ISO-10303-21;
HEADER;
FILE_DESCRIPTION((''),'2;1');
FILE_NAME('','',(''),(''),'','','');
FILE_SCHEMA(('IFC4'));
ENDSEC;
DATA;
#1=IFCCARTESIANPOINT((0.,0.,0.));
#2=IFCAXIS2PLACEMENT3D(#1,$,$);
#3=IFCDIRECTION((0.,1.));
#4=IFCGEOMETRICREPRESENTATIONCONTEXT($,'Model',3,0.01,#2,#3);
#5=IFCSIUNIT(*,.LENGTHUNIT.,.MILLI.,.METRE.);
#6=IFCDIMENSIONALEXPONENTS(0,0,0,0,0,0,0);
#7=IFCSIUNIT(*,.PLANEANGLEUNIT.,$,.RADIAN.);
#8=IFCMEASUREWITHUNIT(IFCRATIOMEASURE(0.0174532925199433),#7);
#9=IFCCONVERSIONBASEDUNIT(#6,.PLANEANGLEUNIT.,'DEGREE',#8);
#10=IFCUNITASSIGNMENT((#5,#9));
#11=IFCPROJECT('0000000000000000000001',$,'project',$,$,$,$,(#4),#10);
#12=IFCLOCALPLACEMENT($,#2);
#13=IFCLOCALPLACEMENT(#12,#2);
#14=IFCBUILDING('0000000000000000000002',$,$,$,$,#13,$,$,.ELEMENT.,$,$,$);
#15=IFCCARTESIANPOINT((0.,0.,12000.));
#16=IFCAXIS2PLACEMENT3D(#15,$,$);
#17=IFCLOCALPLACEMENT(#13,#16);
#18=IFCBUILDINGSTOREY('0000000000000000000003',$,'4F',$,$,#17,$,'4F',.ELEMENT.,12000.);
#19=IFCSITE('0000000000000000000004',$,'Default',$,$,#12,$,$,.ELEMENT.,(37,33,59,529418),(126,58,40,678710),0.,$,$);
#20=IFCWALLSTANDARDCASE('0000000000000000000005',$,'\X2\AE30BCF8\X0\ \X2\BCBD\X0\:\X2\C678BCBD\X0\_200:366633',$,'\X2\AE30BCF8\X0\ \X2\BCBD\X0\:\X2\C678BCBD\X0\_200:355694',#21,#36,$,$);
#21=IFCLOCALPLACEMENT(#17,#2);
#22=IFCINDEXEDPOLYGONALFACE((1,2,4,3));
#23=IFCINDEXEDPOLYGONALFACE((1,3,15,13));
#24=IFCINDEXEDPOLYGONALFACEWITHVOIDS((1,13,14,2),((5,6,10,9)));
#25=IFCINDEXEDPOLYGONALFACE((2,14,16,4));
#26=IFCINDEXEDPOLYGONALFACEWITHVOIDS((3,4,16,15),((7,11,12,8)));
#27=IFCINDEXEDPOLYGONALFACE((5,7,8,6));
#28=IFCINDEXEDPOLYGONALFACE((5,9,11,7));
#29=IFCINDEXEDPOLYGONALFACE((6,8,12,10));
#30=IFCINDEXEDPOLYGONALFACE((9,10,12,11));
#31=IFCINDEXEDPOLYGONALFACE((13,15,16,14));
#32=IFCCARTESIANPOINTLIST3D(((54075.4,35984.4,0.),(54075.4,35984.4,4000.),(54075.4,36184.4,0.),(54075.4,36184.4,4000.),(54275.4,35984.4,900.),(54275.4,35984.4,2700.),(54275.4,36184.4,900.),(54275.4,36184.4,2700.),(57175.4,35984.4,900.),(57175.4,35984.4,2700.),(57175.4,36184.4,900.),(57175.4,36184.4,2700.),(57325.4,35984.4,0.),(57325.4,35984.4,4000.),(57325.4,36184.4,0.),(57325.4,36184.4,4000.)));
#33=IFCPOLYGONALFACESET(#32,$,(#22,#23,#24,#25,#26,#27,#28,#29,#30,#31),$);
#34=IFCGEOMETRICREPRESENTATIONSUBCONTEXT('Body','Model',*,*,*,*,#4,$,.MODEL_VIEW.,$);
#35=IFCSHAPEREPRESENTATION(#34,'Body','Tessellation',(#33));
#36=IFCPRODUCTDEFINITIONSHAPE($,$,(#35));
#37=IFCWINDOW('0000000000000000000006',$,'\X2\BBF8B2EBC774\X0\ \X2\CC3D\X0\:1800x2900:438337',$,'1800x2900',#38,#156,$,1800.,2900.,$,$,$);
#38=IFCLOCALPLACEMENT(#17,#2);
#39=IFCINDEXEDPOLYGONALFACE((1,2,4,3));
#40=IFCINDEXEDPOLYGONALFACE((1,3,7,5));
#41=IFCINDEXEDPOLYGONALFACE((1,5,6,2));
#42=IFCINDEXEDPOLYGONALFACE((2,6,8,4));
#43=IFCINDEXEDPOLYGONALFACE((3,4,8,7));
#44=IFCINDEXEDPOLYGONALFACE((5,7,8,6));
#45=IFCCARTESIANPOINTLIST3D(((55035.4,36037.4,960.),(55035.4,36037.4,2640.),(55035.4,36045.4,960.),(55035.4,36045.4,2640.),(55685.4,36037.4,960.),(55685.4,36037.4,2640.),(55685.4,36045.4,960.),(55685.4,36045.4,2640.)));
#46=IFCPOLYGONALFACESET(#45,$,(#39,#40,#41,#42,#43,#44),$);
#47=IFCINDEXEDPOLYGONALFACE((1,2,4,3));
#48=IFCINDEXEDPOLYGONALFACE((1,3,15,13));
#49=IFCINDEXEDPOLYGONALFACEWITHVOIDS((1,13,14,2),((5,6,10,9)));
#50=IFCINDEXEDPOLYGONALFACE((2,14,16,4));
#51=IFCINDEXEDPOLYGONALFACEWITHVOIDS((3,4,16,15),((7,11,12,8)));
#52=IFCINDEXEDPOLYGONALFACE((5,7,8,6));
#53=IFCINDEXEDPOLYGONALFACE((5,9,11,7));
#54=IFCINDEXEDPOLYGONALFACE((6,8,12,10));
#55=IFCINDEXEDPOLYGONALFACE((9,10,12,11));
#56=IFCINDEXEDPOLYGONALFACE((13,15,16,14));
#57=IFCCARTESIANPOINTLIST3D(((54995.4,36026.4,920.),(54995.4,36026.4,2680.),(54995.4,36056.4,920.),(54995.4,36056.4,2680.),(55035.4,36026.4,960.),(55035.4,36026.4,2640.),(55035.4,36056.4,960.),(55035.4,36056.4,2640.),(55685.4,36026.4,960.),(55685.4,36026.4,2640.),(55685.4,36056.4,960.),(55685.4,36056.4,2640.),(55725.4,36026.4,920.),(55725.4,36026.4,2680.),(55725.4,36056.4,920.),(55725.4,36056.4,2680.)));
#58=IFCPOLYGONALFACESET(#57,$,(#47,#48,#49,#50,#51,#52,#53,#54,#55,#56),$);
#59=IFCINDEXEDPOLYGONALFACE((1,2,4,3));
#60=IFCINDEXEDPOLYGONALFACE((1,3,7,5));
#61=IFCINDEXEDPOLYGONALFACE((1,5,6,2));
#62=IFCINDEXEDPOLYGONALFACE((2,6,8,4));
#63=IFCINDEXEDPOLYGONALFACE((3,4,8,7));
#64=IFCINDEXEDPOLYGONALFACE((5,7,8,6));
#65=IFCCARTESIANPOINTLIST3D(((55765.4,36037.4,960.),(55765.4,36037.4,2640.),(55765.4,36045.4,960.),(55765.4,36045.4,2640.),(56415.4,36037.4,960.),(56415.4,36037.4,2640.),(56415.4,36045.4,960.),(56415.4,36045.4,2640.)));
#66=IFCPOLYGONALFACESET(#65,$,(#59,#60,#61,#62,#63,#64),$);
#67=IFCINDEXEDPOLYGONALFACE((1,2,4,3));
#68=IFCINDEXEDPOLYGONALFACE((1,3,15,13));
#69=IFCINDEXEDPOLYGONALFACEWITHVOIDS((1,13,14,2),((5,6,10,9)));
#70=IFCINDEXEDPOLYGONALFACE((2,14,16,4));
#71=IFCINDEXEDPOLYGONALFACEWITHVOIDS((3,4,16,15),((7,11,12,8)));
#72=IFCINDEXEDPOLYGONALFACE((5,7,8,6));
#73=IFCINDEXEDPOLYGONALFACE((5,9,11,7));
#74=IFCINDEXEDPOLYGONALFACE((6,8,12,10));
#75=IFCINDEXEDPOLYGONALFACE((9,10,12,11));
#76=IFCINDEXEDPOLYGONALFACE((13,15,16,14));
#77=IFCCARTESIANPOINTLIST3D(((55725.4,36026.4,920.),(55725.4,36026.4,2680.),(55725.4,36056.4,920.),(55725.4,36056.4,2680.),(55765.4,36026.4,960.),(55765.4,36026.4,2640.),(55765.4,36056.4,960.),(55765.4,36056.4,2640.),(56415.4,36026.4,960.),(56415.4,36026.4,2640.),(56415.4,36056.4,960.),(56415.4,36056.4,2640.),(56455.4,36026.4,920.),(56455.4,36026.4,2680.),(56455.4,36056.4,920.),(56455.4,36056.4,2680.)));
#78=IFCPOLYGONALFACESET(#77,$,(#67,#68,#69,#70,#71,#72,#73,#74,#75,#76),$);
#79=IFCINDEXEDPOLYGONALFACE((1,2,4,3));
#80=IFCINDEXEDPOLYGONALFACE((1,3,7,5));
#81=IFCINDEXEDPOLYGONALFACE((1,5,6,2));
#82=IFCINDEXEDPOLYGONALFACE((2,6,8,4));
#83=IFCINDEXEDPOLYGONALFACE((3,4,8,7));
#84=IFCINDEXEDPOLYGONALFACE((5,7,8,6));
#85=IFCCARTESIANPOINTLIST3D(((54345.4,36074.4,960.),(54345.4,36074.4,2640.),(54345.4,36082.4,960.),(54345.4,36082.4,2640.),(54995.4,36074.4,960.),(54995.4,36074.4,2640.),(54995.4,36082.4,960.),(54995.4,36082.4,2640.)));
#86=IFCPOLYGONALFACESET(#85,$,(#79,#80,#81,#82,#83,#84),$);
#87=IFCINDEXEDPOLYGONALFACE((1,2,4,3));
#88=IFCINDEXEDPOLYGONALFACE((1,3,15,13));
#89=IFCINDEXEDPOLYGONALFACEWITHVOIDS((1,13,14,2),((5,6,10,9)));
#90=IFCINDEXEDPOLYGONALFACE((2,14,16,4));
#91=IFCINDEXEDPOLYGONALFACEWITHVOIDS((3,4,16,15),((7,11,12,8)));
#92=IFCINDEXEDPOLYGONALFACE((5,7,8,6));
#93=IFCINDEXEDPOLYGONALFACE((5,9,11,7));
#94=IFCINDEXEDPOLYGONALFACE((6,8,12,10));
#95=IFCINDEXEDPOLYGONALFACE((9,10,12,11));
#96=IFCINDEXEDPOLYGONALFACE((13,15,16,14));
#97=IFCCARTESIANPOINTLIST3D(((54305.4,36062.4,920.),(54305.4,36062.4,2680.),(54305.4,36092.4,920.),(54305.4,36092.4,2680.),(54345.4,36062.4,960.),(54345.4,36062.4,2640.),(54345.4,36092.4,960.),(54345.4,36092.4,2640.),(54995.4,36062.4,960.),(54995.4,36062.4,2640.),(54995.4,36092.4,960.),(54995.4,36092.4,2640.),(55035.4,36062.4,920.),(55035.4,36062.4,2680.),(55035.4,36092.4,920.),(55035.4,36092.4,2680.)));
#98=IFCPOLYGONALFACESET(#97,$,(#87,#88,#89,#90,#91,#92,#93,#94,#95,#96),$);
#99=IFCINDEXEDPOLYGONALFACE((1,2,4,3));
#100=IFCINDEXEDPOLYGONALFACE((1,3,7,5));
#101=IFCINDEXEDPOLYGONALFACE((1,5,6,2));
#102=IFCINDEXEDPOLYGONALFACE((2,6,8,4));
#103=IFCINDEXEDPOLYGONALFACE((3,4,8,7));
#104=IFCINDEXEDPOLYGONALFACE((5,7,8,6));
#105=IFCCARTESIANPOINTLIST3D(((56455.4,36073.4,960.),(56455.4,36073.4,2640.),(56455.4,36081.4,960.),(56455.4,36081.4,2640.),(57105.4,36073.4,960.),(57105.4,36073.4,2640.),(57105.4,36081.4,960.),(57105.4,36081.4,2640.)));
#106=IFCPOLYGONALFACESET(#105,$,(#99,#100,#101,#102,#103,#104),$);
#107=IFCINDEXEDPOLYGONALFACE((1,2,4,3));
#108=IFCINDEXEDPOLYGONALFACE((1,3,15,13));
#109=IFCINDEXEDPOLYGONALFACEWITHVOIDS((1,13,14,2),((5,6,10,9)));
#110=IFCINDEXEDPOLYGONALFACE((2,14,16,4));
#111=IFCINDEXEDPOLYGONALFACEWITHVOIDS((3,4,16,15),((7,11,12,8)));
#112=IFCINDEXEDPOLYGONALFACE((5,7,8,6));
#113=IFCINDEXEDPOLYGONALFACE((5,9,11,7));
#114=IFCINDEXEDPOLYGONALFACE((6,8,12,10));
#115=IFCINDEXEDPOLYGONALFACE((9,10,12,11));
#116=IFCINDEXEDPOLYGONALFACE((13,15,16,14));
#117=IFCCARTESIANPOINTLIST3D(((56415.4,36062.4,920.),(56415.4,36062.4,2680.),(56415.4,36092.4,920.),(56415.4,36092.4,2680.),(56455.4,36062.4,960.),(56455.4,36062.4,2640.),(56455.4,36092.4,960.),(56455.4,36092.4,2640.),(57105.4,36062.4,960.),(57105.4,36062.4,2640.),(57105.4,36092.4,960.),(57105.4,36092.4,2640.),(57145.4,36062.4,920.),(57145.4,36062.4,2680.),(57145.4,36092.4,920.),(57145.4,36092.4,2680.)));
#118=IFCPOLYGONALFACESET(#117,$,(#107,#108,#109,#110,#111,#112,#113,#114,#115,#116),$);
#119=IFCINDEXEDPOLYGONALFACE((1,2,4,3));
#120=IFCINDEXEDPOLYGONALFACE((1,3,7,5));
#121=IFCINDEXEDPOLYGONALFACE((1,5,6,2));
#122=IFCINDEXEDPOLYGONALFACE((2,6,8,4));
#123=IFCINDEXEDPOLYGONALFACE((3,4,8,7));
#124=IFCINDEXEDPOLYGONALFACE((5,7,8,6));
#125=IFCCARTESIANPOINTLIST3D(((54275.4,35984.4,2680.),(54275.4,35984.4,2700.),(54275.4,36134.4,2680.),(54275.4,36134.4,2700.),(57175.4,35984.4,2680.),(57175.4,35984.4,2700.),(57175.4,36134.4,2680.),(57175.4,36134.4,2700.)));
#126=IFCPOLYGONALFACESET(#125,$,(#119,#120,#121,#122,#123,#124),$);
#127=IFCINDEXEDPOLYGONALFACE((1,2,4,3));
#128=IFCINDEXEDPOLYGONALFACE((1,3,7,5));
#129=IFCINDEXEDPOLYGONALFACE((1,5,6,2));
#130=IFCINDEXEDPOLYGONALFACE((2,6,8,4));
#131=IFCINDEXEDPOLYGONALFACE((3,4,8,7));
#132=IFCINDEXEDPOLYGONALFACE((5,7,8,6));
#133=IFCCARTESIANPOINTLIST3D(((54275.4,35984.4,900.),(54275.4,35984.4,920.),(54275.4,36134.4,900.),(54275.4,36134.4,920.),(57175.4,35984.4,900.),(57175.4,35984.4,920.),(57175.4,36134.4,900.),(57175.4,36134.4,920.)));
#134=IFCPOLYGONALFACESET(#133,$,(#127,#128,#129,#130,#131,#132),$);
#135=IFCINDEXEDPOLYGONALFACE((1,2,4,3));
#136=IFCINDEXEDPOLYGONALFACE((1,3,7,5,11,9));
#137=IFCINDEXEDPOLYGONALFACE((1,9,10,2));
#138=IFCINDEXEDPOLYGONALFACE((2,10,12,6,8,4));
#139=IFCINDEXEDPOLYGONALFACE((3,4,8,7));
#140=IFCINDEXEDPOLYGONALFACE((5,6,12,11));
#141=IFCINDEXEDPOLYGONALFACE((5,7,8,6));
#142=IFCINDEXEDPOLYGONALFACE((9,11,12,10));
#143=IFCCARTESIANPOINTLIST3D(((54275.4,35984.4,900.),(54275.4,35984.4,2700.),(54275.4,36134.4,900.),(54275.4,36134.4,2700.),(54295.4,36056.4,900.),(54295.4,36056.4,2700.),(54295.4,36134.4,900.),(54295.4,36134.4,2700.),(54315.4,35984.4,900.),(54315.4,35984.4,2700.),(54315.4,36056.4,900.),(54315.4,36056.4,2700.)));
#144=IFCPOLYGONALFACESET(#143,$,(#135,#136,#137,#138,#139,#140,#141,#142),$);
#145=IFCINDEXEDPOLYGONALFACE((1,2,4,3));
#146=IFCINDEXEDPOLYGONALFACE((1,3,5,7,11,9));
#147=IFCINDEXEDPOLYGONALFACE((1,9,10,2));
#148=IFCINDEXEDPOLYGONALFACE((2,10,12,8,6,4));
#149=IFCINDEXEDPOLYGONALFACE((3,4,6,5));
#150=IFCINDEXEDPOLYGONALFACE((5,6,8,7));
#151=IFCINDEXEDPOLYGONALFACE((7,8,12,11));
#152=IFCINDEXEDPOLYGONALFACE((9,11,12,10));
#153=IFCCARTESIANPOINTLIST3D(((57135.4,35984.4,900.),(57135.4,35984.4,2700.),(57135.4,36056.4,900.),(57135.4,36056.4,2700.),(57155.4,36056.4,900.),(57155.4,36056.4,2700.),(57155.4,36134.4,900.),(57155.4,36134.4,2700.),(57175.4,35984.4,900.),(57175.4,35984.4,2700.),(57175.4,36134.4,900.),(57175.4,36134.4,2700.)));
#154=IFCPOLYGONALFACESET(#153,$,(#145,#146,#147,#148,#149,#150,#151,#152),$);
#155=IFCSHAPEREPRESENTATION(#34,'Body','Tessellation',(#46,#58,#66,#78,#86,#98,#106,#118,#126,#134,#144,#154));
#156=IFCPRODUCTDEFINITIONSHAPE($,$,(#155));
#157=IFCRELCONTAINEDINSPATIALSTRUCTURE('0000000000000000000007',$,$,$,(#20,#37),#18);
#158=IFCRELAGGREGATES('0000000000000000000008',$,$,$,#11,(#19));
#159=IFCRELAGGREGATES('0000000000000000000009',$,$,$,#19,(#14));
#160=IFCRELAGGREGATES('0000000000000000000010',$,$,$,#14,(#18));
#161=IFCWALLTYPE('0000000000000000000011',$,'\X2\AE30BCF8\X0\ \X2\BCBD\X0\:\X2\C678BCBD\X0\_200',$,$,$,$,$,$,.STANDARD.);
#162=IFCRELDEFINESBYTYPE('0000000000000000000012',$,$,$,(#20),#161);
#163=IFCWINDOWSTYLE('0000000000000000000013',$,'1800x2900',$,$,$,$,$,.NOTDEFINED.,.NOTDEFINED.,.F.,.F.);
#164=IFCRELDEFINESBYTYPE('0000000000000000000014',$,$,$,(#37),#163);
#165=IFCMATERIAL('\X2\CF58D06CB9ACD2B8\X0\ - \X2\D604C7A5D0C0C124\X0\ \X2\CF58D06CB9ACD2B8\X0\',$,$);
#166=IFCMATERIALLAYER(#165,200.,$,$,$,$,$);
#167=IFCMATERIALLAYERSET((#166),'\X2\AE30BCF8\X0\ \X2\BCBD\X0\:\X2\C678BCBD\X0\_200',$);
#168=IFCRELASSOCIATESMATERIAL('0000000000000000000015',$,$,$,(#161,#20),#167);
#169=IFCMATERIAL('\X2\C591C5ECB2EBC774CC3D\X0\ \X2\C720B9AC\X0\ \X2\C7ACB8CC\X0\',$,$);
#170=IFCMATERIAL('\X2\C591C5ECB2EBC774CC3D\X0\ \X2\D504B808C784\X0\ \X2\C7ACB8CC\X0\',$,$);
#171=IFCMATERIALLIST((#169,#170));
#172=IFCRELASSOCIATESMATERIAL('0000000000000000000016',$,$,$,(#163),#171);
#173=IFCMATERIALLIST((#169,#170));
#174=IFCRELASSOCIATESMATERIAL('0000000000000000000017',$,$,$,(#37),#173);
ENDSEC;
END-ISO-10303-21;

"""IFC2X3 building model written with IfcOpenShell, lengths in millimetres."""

from ifc_helpers import new_model, entity, si_unit, converted_unit, direction, frame, frame_2d, origin, origin_2d_with_axis, place, context, subcontext, project, spatial, polyline, rectangle, outline, extrude, source, transform, mapped, material, material_list, layer, layer_set, layer_usage, type_object, type_shapes, element, fill, save


model = new_model("IFC2X3")

# Units and contexts
model_context = context("Model", 3, precision=0.01, world=origin(), true_north=direction((0.0, 1.0)))
body_context = subcontext(model_context, "Body", "Model", "MODEL_VIEW")
ifc_project = project(units=[si_unit("LENGTHUNIT", "METRE", prefix="MILLI"), converted_unit("PLANEANGLEUNIT", "DEGREE", entity("IfcRatioMeasure", 0.0174532925199433), si_unit("PLANEANGLEUNIT", "RADIAN"), dimensions=[0, 0, 0, 0, 0, 0, 0])], contexts=[model_context])

# Site, building, storey
site_placement = place(None, origin())
site = spatial("IfcSite", under=ifc_project, at=site_placement, Name="Default", CompositionType="ELEMENT", RefLatitude=(37, 33, 59, 529418), RefLongitude=(126, 58, 40, 678710), RefElevation=0.0)
building_placement = place(site_placement, origin())
building = spatial("IfcBuilding", under=site, at=building_placement, CompositionType="ELEMENT")
storey_placement = place(building_placement, frame((0.0, 0.0, 12000.0)))
storey = spatial("IfcBuildingStorey", under=building, at=storey_placement, Name="4F", LongName="4F", CompositionType="ELEMENT", Elevation=12000.0)

# Wall, opening, window
ifc_material_1 = material(Name="콘크리트 - 현장타설 콘크리트")
ifc_layer_1 = layer(ifc_material_1, 200.0)
ifc_layer_set_1 = layer_set([ifc_layer_1], Name="기본 벽:외벽_200")
ifc_layer_usage_1 = layer_usage(ifc_layer_set_1, "AXIS2", "NEGATIVE", 100.0)
wall_type_1 = type_object("IfcWallType", Name="기본 벽:외벽_200", PredefinedType="STANDARD", material=ifc_layer_set_1)
wall_1_placement = place(storey_placement, frame((57325.4, 36084.4, 0.0), z_axis=(0.0, 0.0, 1.0), x_axis=(-1.0, 0.0, 0.0)))
wall_1 = element("IfcWallStandardCase", 1, at=wall_1_placement, inside=storey, type_object=wall_type_1, material=ifc_layer_usage_1, Name="기본 벽:외벽_200:366633", ObjectType="기본 벽:외벽_200:355694", context=body_context, shape_type="SweptSolid", body=[
    extrude(rectangle(XDim=3250.0, YDim=200.0, at=frame_2d((1625.0, 0.0), x_axis=(-1.0, 0.0))), origin(), (0.0, 0.0, 1.0), 4000.0),
])
opening_1_placement = place(wall_1_placement, frame((150.0, -100.0, 900.0)))
opening_1 = element("IfcOpeningElement", 2, at=opening_1_placement, cuts=wall_1, ObjectType="Opening", context=body_context, shape_type="SweptSolid", body=[
    extrude(rectangle(XDim=1800.0, YDim=2900.0, at=frame_2d((900.0, 1450.0), x_axis=(1.0, 0.0))), frame((0.0, 0.0, 0.0), z_axis=(0.0, 1.0, 0.0), x_axis=(0.0, 0.0, 1.0)), (0.0, 0.0, 1.0), 200.0),
])
ifc_material_2 = material(Name="양여닫이창 유리 재료")
ifc_material_3 = material(Name="양여닫이창 프레임 재료")
ifc_material_list_1 = material_list([ifc_material_2, ifc_material_3])
ifc_material_list_2 = material_list([ifc_material_2, ifc_material_3])
window_style = type_object("IfcWindowStyle", Name="1800x2900", ConstructionType="NOTDEFINED", OperationType="NOTDEFINED", ParameterTakesPrecedence=False, Sizeable=False, material=ifc_material_list_2)
shared_shape_1 = source(origin(), body_context, "Body", "SweptSolid", [
    extrude(rectangle(XDim=8.0, YDim=650.0, at=frame_2d((0.0, 0.0), x_axis=(1.0, 0.0))), frame((1815.0, 143.0, 60.0), z_axis=(0.0, 0.0, 1.0), x_axis=(0.0, 1.0, 0.0)), (0.0, 0.0, 1.0), 1680.0),
    extrude(outline(polyline([(-880.0, -365.0), (880.0, -365.0), (880.0, 365.0), (-880.0, 365.0), (-880.0, -365.0)]), holes=[polyline([(840.0, -325.0), (-840.0, -325.0), (-840.0, 325.0), (840.0, 325.0), (840.0, -325.0)])]), frame((1815.0, 128.0, 900.0), z_axis=(0.0, 1.0, 0.0), x_axis=(0.0, 0.0, -1.0)), (0.0, 0.0, 1.0), 30.0),
    extrude(rectangle(XDim=8.0, YDim=650.0, at=frame_2d((0.0, 0.0), x_axis=(1.0, 0.0))), frame((1085.0, 143.0, 60.0), z_axis=(0.0, 0.0, 1.0), x_axis=(0.0, 1.0, 0.0)), (0.0, 0.0, 1.0), 1680.0),
    extrude(outline(polyline([(-880.0, -365.0), (880.0, -365.0), (880.0, 365.0), (-880.0, 365.0), (-880.0, -365.0)]), holes=[polyline([(840.0, -325.0), (-840.0, -325.0), (-840.0, 325.0), (840.0, 325.0), (840.0, -325.0)])]), frame((1085.0, 128.0, 900.0), z_axis=(0.0, 1.0, 0.0), x_axis=(0.0, 0.0, -1.0)), (0.0, 0.0, 1.0), 30.0),
    extrude(rectangle(XDim=8.0, YDim=650.0, at=frame_2d((0.0, 0.0), x_axis=(1.0, 0.0))), frame((2505.0, 106.0, 60.0), z_axis=(0.0, 0.0, 1.0), x_axis=(0.0, 1.0, 0.0)), (0.0, 0.0, 1.0), 1680.0),
    extrude(outline(polyline([(-880.0, -365.0), (880.0, -365.0), (880.0, 365.0), (-880.0, 365.0), (-880.0, -365.0)]), holes=[polyline([(840.0, -325.0), (-840.0, -325.0), (-840.0, 325.0), (840.0, 325.0), (840.0, -325.0)])]), frame((2505.0, 92.0, 900.0), z_axis=(0.0, 1.0, 0.0), x_axis=(0.0, 0.0, -1.0)), (0.0, 0.0, 1.0), 30.0),
    extrude(rectangle(XDim=8.0, YDim=650.0, at=origin_2d_with_axis()), frame((395.0, 107.0, 60.0), z_axis=(0.0, 0.0, 1.0), x_axis=(0.0, 1.0, 0.0)), (0.0, 0.0, 1.0), 1680.0),
    extrude(outline(polyline([(-880.0, -365.0), (880.0, -365.0), (880.0, 365.0), (-880.0, 365.0), (-880.0, -365.0)]), holes=[polyline([(840.0, -325.0), (-840.0, -325.0), (-840.0, 325.0), (840.0, 325.0), (840.0, -325.0)])]), frame((395.0, 92.0, 900.0), z_axis=(0.0, 1.0, 0.0), x_axis=(0.0, 0.0, -1.0)), (0.0, 0.0, 1.0), 30.0),
    extrude(rectangle(XDim=2900.0, YDim=150.0, at=origin_2d_with_axis()), frame((1450.0, 125.0, 1780.0), z_axis=(0.0, 0.0, 1.0), x_axis=(-1.0, 0.0, 0.0)), (0.0, 0.0, 1.0), 20.0),
    extrude(rectangle(XDim=2900.0, YDim=150.0, at=origin_2d_with_axis()), frame((1450.0, 125.0, 0.0), z_axis=(0.0, 0.0, 1.0), x_axis=(-1.0, 0.0, 0.0)), (0.0, 0.0, 1.0), 20.0),
    extrude(outline(polyline([(-74.0, -20.0), (-2.0, -20.0), (-2.0, 0.0), (76.0, 0.0), (76.0, 20.0), (-74.0, 20.0), (-74.0, -20.0)])), frame((2880.0, 126.0, 0.0), z_axis=(0.0, 0.0, 1.0), x_axis=(0.0, -1.0, 0.0)), (0.0, 0.0, 1.0), 1800.0),
    extrude(outline(polyline([(-20.0, -74.0), (20.0, -74.0), (20.0, 76.0), (0.0, 76.0), (0.0, -2.0), (-20.0, -2.0), (-20.0, -74.0)])), frame((20.0, 126.0, 0.0), z_axis=(0.0, 0.0, 1.0), x_axis=(-1.0, 0.0, 0.0)), (0.0, 0.0, 1.0), 1800.0),
])
type_shapes(window_style, [shared_shape_1])
window_1_placement = place(opening_1_placement, origin())
window_1 = element("IfcWindow", 3, at=window_1_placement, inside=storey, type_object=window_style, material=ifc_material_list_1, Name="미닫이 창:1800x2900:438337", ObjectType="1800x2900", OverallHeight=1800.0, OverallWidth=2900.0, context=body_context, shape_type="MappedRepresentation", body=[
    mapped(shared_shape_1, transform((0.0, 0.0, 0.0), scale=1.0)),
])
fill(opening_1, window_1)

save(model, "model.ifc")
